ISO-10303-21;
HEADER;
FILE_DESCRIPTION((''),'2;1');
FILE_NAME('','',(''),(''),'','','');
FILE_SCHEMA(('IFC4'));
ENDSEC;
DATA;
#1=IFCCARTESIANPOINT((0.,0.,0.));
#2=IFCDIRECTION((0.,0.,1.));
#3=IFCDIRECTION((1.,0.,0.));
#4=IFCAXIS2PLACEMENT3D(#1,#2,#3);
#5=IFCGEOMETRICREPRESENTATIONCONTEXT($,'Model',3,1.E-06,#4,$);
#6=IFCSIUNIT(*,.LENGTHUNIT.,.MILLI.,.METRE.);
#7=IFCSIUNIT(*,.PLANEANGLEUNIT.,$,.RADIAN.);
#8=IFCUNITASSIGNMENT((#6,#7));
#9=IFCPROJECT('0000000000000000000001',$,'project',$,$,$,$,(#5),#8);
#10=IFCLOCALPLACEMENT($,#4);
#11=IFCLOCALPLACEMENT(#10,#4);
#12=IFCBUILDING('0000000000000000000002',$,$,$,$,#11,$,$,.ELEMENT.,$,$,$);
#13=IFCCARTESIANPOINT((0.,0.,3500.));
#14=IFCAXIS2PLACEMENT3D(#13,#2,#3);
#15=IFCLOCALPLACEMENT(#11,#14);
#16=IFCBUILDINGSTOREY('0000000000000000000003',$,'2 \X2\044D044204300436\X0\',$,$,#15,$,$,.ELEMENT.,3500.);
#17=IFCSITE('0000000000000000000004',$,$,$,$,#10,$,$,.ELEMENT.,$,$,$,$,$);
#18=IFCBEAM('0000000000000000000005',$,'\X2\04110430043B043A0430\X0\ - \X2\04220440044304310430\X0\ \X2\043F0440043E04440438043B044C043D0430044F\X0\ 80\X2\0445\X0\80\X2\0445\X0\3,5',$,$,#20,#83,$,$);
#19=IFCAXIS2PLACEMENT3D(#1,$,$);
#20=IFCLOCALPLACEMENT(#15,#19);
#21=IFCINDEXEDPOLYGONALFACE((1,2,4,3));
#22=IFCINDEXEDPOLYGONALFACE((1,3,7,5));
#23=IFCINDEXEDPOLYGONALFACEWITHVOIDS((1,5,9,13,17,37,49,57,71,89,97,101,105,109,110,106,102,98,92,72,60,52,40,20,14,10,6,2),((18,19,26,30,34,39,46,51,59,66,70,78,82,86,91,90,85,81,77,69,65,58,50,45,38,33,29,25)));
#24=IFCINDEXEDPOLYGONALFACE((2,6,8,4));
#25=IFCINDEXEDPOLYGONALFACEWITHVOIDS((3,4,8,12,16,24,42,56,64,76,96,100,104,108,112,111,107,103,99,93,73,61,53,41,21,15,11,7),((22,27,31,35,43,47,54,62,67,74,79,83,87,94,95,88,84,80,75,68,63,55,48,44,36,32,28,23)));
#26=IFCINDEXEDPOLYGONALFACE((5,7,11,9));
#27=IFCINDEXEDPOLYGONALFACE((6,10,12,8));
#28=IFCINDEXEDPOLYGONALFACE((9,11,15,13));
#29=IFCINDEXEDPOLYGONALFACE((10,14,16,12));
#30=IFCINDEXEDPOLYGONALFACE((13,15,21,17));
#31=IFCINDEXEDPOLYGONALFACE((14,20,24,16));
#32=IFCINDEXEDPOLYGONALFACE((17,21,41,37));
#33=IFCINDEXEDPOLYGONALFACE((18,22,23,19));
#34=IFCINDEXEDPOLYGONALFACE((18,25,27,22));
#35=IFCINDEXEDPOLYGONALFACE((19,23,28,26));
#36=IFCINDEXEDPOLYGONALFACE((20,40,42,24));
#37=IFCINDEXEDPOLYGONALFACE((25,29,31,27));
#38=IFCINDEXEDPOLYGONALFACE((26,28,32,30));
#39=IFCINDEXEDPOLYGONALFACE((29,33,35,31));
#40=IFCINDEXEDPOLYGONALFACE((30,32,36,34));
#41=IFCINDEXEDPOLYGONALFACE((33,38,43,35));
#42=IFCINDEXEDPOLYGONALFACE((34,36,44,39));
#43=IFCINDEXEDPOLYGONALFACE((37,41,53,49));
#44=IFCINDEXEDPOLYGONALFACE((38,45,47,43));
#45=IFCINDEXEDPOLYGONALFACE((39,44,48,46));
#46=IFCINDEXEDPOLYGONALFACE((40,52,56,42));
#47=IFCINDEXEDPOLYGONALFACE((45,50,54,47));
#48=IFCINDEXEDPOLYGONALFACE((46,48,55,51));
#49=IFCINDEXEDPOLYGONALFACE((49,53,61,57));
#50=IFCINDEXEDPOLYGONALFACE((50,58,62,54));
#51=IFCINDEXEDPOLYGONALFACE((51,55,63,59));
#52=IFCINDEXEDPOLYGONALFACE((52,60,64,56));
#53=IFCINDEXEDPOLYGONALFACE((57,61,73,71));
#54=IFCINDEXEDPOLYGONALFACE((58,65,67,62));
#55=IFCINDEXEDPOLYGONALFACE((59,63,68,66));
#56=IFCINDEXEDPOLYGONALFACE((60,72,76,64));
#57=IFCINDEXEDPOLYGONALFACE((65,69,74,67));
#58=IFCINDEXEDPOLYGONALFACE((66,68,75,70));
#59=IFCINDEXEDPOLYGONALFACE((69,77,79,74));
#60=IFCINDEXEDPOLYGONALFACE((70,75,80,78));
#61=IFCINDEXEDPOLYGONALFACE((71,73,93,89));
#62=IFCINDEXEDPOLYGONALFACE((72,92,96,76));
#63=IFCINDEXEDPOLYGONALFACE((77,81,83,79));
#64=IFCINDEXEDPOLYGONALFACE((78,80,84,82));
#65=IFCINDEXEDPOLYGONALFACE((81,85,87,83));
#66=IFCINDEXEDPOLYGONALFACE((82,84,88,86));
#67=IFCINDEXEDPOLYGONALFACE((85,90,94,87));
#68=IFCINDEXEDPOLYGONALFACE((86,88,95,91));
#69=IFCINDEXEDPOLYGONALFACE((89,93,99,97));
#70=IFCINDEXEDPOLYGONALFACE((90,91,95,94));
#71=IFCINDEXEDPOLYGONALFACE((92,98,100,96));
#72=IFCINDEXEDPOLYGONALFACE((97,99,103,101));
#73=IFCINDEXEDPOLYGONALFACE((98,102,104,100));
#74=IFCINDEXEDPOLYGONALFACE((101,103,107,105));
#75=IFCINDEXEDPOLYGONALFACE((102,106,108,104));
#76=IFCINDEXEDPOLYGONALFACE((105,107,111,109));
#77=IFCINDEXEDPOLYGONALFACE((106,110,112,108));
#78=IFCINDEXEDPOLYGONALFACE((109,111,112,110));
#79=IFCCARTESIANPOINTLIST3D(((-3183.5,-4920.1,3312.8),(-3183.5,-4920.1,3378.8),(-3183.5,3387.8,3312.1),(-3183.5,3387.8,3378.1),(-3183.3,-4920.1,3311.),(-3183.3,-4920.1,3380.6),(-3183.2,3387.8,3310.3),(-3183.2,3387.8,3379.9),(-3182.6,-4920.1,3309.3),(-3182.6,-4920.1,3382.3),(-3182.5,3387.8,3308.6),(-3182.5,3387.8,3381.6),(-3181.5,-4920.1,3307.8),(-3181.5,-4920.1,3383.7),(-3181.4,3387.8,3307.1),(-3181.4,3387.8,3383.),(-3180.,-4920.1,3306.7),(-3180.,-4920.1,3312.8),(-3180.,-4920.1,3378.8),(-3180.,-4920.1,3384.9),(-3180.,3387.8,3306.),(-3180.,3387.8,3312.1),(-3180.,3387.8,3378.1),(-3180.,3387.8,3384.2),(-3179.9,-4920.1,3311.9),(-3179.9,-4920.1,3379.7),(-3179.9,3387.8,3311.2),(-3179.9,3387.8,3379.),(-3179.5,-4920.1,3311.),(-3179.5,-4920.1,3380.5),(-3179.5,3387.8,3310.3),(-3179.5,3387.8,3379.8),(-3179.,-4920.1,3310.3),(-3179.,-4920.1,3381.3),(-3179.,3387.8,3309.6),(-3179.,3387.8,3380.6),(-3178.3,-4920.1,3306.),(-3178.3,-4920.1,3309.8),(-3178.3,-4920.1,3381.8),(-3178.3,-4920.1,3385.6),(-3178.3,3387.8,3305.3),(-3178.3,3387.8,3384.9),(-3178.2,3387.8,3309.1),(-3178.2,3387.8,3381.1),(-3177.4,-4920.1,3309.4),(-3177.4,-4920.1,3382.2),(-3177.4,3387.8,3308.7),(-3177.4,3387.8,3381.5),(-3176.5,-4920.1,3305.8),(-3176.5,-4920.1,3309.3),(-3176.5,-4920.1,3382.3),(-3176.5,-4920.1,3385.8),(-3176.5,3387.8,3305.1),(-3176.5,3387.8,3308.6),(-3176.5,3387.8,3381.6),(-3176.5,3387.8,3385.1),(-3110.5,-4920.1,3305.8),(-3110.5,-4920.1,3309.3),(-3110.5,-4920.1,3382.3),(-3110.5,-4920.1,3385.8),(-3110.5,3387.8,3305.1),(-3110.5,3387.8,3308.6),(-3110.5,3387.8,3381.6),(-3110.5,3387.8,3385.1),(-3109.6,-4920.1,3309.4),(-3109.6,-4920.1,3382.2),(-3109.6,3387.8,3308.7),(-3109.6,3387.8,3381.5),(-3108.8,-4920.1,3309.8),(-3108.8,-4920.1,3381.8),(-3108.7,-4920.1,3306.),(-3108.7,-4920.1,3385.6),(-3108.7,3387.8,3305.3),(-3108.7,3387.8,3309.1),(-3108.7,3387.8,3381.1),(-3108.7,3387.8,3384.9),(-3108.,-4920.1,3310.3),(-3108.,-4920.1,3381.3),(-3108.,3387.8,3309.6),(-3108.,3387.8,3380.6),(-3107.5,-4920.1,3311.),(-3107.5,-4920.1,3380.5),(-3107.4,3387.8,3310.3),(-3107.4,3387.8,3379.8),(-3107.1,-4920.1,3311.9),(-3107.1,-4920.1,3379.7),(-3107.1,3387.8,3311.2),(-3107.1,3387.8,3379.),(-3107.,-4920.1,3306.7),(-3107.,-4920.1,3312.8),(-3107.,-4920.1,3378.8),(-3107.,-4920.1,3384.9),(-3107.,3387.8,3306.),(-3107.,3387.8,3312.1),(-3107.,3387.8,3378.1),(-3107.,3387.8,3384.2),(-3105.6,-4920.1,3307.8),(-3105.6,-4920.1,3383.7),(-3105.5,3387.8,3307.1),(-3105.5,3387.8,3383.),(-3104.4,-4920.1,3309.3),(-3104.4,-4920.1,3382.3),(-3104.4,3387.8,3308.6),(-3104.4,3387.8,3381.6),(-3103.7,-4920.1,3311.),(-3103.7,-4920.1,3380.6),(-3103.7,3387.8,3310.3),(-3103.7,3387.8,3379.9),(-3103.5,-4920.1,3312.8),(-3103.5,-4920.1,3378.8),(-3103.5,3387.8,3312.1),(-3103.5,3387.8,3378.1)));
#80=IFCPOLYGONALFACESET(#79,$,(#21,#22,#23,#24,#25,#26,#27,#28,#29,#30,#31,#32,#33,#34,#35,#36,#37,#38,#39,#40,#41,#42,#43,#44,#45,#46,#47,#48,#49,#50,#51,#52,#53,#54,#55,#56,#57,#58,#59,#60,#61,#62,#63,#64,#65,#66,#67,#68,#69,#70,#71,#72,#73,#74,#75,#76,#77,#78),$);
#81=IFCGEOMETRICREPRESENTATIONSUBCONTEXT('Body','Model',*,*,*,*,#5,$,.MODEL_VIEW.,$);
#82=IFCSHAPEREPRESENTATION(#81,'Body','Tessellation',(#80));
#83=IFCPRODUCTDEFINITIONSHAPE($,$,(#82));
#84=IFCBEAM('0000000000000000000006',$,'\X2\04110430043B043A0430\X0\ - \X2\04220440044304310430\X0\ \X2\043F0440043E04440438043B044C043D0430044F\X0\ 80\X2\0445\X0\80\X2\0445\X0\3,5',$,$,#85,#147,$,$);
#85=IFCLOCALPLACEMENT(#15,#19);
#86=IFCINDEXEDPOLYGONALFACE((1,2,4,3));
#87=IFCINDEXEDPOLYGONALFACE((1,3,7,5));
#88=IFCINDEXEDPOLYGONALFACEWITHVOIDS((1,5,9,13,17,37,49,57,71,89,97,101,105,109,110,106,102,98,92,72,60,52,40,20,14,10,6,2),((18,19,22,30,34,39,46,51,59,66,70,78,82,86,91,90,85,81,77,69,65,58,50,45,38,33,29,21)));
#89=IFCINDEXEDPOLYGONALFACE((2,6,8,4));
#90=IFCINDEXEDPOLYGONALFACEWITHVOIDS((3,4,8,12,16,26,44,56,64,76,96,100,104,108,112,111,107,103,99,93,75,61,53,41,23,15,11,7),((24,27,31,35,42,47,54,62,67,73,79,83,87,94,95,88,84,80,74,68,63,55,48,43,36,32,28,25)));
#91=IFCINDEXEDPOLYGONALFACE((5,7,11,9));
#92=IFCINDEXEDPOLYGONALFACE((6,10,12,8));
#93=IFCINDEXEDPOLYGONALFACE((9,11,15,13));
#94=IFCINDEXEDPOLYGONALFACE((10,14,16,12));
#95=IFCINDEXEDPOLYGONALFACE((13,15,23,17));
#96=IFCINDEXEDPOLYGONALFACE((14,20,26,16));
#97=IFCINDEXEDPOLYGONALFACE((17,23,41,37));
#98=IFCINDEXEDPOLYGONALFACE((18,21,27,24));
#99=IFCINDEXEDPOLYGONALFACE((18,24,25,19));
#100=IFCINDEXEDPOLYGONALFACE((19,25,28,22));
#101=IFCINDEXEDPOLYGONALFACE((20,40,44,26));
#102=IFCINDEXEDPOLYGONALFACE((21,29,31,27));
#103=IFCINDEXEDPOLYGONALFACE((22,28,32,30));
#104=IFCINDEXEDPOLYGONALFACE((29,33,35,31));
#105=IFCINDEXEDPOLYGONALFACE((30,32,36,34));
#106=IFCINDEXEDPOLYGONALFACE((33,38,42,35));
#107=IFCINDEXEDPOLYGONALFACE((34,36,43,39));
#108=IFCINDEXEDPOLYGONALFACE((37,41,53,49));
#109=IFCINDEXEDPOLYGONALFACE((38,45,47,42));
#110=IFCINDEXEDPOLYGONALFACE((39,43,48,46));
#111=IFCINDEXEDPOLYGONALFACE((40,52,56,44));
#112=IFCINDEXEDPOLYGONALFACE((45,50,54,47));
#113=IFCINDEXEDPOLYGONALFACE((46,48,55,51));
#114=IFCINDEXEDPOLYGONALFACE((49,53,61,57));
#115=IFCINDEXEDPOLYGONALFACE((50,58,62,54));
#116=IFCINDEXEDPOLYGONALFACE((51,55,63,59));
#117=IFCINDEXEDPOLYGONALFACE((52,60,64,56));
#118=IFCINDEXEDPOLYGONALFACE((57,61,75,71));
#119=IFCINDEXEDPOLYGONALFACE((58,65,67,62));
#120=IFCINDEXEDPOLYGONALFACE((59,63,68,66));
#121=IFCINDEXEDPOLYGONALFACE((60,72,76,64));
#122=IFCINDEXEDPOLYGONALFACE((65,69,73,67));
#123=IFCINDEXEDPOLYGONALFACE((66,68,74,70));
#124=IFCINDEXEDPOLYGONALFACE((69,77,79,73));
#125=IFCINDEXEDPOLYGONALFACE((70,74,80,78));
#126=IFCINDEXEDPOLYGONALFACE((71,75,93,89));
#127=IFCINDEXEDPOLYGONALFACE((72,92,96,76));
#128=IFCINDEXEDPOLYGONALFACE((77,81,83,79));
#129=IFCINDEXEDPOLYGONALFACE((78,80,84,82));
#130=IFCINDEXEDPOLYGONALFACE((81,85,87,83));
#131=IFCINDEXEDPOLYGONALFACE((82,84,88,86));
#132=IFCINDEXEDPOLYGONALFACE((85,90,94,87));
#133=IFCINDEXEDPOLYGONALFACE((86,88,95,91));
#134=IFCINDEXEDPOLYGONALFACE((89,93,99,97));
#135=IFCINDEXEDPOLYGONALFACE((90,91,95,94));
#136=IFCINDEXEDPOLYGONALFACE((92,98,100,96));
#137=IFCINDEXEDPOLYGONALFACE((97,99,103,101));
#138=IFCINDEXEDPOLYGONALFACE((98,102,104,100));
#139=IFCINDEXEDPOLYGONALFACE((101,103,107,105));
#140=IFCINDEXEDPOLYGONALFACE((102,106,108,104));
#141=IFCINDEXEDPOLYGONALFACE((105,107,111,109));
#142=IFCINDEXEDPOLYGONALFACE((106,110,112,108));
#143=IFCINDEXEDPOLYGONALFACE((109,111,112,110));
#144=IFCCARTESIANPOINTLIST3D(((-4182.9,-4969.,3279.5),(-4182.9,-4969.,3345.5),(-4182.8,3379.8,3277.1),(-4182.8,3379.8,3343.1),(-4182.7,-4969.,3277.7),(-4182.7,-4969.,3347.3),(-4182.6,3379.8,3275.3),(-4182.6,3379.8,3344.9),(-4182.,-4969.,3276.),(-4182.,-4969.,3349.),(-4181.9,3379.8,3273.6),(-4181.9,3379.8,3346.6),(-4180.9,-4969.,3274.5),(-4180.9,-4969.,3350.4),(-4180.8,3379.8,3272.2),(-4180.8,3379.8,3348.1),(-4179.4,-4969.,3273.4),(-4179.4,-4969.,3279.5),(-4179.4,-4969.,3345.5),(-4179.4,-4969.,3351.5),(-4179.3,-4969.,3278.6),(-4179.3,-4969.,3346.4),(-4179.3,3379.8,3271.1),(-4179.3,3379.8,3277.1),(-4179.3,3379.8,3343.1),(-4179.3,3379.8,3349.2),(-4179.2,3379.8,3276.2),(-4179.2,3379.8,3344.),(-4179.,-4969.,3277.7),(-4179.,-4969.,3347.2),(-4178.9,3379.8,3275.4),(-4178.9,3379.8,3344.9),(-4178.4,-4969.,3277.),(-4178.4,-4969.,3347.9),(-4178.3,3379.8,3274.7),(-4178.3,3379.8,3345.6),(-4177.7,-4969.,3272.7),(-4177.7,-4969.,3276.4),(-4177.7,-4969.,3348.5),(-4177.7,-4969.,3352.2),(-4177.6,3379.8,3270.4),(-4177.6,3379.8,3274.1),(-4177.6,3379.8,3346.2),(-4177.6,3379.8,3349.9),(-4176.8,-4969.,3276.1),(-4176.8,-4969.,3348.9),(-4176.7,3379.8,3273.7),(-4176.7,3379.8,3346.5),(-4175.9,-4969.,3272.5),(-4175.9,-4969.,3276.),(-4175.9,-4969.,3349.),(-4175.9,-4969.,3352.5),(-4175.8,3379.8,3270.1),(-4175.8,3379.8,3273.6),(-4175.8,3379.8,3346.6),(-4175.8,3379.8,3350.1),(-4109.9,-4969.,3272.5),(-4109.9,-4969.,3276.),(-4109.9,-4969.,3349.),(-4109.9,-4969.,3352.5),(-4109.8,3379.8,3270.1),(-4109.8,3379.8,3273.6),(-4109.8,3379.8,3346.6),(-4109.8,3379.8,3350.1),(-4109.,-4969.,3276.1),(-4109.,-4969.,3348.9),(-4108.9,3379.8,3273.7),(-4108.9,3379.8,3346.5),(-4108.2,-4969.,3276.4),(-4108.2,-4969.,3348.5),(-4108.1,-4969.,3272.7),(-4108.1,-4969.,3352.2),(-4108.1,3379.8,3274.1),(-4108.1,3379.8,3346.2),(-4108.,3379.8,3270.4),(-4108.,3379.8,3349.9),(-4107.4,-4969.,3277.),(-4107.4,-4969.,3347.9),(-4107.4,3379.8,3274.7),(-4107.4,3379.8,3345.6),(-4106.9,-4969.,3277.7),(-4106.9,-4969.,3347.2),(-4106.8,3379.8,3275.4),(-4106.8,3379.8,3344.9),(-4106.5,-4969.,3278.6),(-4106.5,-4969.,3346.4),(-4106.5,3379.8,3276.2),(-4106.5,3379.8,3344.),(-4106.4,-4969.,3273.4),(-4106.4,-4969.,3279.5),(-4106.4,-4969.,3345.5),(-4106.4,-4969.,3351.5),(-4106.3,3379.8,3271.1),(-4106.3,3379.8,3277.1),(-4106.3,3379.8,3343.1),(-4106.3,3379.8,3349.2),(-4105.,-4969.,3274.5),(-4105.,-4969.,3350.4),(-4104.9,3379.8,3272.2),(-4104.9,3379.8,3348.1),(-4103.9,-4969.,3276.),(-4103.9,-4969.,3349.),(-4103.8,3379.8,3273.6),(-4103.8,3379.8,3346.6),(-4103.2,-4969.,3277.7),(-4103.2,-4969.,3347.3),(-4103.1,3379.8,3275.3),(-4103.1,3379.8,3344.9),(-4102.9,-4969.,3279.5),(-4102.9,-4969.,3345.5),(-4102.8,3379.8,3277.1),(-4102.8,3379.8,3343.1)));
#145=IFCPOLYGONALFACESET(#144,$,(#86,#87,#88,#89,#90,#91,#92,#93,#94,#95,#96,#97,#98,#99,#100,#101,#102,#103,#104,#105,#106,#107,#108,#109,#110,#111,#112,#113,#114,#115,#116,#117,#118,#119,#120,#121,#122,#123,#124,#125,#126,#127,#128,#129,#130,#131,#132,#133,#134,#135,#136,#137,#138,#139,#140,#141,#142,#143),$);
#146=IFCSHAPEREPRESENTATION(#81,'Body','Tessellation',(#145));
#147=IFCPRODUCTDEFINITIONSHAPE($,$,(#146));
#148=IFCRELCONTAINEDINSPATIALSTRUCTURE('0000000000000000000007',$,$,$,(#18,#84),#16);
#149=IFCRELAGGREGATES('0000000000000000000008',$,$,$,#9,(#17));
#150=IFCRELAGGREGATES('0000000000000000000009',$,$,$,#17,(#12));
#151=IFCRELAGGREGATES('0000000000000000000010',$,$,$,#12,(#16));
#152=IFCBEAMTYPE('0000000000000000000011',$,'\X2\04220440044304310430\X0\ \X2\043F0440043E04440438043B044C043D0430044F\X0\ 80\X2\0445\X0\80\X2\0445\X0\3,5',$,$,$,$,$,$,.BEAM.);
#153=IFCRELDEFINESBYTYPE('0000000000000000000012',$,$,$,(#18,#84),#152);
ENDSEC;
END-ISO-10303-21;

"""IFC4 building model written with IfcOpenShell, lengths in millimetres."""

from ifc_helpers import new_model, si_unit, frame, origin_with_axes, place, context, subcontext, project, spatial, line, arc, indexed_curve, outline, extrude, source, transform, mapped, type_object, element, save


model = new_model("IFC4")

# Units and contexts
model_context = context("Model", 3, precision=1e-06, world=origin_with_axes())
body_context = subcontext(model_context, "Body", "Model", "MODEL_VIEW")
ifc_project = project(units=[si_unit("LENGTHUNIT", "METRE", prefix="MILLI"), si_unit("PLANEANGLEUNIT", "RADIAN")], contexts=[model_context])

# Site, building, storey
site_placement = place(None, origin_with_axes())
site = spatial("IfcSite", under=ifc_project, at=site_placement, CompositionType="ELEMENT")
building_placement = place(site_placement, origin_with_axes())
building = spatial("IfcBuilding", under=site, at=building_placement, CompositionType="ELEMENT")
storey_placement = place(building_placement, frame((0.0, 0.0, 3500.0), z_axis=(0.0, 0.0, 1.0), x_axis=(1.0, 0.0, 0.0)))
storey = spatial("IfcBuildingStorey", under=building, at=storey_placement, Name="2 этаж", CompositionType="ELEMENT", Elevation=3500.0)

# Beams
beam_type = type_object("IfcBeamType", Name="Труба профильная 80х80х3,5", PredefinedType="BEAM")
shared_shape_1 = source(origin_with_axes(), body_context, "Body", "SweptSolid", [
    extrude(outline(indexed_curve([(-40.0, -73.0), (-37.9, -77.9), (-33.0, -80.0), (33.0, -80.0), (37.9, -77.9), (40.0, -73.0), (40.0, -7.0), (37.9, -2.1), (33.0, 0.0), (-33.0, 0.0), (-37.9, -2.1), (-40.0, -7.0)], segments=[arc(1, 2, 3), line(3, 4), arc(4, 5, 6), line(6, 7), arc(7, 8, 9), line(9, 10), arc(10, 11, 12), line(12, 1)]), holes=[indexed_curve([(-36.5, -7.0), (-35.5, -4.5), (-33.0, -3.5), (33.0, -3.5), (35.5, -4.5), (36.5, -7.0), (36.5, -73.0), (35.5, -75.5), (33.0, -76.5), (-33.0, -76.5), (-35.5, -75.5), (-36.5, -73.0)], segments=[arc(1, 2, 3), line(3, 4), arc(4, 5, 6), line(6, 7), arc(7, 8, 9), line(9, 10), arc(10, 11, 12), line(12, 1)])]), origin_with_axes(), (0.0, 0.0, -1.0), 8307.9),
])
beam_1_placement = place(storey_placement, frame((-3143.5, 3387.8, 3385.1), z_axis=(0.000003, 1.0, -0.000084), x_axis=(-1.0, 0.000003, 0.0)))
element("IfcBeam", 1, at=beam_1_placement, inside=storey, type_object=beam_type, Name="Балка - Труба профильная 80х80х3,5", context=body_context, shape_type="MappedRepresentation", body=[
    mapped(shared_shape_1, transform((0.0, 0.0, 0.0), x_axis=(1.0, 0.0, 0.0), y_axis=(0.0, 1.0, 0.0), z_axis=(0.0, 0.0, 1.0), scale=1.0)),
])
shared_shape_2 = source(origin_with_axes(), body_context, "Body", "SweptSolid", [
    extrude(outline(indexed_curve([(-40.0, -73.0), (-37.9, -77.9), (-33.0, -80.0), (33.0, -80.0), (37.9, -77.9), (40.0, -73.0), (40.0, -7.0), (37.9, -2.1), (33.0, 0.0), (-33.0, 0.0), (-37.9, -2.1), (-40.0, -7.0)], segments=[arc(1, 2, 3), line(3, 4), arc(4, 5, 6), line(6, 7), arc(7, 8, 9), line(9, 10), arc(10, 11, 12), line(12, 1)]), holes=[indexed_curve([(-36.5, -7.0), (-35.5, -4.5), (-33.0, -3.5), (33.0, -3.5), (35.5, -4.5), (36.5, -7.0), (36.5, -73.0), (35.5, -75.5), (33.0, -76.5), (-33.0, -76.5), (-35.5, -75.5), (-36.5, -73.0)], segments=[arc(1, 2, 3), line(3, 4), arc(4, 5, 6), line(6, 7), arc(7, 8, 9), line(9, 10), arc(10, 11, 12), line(12, 1)])]), origin_with_axes(), (0.0, 0.0, -1.0), 8348.8),
])
beam_2_placement = place(storey_placement, frame((-4142.8, 3379.8, 3350.1), z_axis=(0.00001, 1.0, -0.000281), x_axis=(-1.0, 0.00001, 0.0)))
element("IfcBeam", 2, at=beam_2_placement, inside=storey, type_object=beam_type, Name="Балка - Труба профильная 80х80х3,5", context=body_context, shape_type="MappedRepresentation", body=[
    mapped(shared_shape_2, transform((0.0, 0.0, 0.0), x_axis=(1.0, 0.0, 0.0), y_axis=(0.0, 1.0, 0.0), z_axis=(0.0, 0.0, 1.0), scale=1.0)),
])

save(model, "model.ifc")
